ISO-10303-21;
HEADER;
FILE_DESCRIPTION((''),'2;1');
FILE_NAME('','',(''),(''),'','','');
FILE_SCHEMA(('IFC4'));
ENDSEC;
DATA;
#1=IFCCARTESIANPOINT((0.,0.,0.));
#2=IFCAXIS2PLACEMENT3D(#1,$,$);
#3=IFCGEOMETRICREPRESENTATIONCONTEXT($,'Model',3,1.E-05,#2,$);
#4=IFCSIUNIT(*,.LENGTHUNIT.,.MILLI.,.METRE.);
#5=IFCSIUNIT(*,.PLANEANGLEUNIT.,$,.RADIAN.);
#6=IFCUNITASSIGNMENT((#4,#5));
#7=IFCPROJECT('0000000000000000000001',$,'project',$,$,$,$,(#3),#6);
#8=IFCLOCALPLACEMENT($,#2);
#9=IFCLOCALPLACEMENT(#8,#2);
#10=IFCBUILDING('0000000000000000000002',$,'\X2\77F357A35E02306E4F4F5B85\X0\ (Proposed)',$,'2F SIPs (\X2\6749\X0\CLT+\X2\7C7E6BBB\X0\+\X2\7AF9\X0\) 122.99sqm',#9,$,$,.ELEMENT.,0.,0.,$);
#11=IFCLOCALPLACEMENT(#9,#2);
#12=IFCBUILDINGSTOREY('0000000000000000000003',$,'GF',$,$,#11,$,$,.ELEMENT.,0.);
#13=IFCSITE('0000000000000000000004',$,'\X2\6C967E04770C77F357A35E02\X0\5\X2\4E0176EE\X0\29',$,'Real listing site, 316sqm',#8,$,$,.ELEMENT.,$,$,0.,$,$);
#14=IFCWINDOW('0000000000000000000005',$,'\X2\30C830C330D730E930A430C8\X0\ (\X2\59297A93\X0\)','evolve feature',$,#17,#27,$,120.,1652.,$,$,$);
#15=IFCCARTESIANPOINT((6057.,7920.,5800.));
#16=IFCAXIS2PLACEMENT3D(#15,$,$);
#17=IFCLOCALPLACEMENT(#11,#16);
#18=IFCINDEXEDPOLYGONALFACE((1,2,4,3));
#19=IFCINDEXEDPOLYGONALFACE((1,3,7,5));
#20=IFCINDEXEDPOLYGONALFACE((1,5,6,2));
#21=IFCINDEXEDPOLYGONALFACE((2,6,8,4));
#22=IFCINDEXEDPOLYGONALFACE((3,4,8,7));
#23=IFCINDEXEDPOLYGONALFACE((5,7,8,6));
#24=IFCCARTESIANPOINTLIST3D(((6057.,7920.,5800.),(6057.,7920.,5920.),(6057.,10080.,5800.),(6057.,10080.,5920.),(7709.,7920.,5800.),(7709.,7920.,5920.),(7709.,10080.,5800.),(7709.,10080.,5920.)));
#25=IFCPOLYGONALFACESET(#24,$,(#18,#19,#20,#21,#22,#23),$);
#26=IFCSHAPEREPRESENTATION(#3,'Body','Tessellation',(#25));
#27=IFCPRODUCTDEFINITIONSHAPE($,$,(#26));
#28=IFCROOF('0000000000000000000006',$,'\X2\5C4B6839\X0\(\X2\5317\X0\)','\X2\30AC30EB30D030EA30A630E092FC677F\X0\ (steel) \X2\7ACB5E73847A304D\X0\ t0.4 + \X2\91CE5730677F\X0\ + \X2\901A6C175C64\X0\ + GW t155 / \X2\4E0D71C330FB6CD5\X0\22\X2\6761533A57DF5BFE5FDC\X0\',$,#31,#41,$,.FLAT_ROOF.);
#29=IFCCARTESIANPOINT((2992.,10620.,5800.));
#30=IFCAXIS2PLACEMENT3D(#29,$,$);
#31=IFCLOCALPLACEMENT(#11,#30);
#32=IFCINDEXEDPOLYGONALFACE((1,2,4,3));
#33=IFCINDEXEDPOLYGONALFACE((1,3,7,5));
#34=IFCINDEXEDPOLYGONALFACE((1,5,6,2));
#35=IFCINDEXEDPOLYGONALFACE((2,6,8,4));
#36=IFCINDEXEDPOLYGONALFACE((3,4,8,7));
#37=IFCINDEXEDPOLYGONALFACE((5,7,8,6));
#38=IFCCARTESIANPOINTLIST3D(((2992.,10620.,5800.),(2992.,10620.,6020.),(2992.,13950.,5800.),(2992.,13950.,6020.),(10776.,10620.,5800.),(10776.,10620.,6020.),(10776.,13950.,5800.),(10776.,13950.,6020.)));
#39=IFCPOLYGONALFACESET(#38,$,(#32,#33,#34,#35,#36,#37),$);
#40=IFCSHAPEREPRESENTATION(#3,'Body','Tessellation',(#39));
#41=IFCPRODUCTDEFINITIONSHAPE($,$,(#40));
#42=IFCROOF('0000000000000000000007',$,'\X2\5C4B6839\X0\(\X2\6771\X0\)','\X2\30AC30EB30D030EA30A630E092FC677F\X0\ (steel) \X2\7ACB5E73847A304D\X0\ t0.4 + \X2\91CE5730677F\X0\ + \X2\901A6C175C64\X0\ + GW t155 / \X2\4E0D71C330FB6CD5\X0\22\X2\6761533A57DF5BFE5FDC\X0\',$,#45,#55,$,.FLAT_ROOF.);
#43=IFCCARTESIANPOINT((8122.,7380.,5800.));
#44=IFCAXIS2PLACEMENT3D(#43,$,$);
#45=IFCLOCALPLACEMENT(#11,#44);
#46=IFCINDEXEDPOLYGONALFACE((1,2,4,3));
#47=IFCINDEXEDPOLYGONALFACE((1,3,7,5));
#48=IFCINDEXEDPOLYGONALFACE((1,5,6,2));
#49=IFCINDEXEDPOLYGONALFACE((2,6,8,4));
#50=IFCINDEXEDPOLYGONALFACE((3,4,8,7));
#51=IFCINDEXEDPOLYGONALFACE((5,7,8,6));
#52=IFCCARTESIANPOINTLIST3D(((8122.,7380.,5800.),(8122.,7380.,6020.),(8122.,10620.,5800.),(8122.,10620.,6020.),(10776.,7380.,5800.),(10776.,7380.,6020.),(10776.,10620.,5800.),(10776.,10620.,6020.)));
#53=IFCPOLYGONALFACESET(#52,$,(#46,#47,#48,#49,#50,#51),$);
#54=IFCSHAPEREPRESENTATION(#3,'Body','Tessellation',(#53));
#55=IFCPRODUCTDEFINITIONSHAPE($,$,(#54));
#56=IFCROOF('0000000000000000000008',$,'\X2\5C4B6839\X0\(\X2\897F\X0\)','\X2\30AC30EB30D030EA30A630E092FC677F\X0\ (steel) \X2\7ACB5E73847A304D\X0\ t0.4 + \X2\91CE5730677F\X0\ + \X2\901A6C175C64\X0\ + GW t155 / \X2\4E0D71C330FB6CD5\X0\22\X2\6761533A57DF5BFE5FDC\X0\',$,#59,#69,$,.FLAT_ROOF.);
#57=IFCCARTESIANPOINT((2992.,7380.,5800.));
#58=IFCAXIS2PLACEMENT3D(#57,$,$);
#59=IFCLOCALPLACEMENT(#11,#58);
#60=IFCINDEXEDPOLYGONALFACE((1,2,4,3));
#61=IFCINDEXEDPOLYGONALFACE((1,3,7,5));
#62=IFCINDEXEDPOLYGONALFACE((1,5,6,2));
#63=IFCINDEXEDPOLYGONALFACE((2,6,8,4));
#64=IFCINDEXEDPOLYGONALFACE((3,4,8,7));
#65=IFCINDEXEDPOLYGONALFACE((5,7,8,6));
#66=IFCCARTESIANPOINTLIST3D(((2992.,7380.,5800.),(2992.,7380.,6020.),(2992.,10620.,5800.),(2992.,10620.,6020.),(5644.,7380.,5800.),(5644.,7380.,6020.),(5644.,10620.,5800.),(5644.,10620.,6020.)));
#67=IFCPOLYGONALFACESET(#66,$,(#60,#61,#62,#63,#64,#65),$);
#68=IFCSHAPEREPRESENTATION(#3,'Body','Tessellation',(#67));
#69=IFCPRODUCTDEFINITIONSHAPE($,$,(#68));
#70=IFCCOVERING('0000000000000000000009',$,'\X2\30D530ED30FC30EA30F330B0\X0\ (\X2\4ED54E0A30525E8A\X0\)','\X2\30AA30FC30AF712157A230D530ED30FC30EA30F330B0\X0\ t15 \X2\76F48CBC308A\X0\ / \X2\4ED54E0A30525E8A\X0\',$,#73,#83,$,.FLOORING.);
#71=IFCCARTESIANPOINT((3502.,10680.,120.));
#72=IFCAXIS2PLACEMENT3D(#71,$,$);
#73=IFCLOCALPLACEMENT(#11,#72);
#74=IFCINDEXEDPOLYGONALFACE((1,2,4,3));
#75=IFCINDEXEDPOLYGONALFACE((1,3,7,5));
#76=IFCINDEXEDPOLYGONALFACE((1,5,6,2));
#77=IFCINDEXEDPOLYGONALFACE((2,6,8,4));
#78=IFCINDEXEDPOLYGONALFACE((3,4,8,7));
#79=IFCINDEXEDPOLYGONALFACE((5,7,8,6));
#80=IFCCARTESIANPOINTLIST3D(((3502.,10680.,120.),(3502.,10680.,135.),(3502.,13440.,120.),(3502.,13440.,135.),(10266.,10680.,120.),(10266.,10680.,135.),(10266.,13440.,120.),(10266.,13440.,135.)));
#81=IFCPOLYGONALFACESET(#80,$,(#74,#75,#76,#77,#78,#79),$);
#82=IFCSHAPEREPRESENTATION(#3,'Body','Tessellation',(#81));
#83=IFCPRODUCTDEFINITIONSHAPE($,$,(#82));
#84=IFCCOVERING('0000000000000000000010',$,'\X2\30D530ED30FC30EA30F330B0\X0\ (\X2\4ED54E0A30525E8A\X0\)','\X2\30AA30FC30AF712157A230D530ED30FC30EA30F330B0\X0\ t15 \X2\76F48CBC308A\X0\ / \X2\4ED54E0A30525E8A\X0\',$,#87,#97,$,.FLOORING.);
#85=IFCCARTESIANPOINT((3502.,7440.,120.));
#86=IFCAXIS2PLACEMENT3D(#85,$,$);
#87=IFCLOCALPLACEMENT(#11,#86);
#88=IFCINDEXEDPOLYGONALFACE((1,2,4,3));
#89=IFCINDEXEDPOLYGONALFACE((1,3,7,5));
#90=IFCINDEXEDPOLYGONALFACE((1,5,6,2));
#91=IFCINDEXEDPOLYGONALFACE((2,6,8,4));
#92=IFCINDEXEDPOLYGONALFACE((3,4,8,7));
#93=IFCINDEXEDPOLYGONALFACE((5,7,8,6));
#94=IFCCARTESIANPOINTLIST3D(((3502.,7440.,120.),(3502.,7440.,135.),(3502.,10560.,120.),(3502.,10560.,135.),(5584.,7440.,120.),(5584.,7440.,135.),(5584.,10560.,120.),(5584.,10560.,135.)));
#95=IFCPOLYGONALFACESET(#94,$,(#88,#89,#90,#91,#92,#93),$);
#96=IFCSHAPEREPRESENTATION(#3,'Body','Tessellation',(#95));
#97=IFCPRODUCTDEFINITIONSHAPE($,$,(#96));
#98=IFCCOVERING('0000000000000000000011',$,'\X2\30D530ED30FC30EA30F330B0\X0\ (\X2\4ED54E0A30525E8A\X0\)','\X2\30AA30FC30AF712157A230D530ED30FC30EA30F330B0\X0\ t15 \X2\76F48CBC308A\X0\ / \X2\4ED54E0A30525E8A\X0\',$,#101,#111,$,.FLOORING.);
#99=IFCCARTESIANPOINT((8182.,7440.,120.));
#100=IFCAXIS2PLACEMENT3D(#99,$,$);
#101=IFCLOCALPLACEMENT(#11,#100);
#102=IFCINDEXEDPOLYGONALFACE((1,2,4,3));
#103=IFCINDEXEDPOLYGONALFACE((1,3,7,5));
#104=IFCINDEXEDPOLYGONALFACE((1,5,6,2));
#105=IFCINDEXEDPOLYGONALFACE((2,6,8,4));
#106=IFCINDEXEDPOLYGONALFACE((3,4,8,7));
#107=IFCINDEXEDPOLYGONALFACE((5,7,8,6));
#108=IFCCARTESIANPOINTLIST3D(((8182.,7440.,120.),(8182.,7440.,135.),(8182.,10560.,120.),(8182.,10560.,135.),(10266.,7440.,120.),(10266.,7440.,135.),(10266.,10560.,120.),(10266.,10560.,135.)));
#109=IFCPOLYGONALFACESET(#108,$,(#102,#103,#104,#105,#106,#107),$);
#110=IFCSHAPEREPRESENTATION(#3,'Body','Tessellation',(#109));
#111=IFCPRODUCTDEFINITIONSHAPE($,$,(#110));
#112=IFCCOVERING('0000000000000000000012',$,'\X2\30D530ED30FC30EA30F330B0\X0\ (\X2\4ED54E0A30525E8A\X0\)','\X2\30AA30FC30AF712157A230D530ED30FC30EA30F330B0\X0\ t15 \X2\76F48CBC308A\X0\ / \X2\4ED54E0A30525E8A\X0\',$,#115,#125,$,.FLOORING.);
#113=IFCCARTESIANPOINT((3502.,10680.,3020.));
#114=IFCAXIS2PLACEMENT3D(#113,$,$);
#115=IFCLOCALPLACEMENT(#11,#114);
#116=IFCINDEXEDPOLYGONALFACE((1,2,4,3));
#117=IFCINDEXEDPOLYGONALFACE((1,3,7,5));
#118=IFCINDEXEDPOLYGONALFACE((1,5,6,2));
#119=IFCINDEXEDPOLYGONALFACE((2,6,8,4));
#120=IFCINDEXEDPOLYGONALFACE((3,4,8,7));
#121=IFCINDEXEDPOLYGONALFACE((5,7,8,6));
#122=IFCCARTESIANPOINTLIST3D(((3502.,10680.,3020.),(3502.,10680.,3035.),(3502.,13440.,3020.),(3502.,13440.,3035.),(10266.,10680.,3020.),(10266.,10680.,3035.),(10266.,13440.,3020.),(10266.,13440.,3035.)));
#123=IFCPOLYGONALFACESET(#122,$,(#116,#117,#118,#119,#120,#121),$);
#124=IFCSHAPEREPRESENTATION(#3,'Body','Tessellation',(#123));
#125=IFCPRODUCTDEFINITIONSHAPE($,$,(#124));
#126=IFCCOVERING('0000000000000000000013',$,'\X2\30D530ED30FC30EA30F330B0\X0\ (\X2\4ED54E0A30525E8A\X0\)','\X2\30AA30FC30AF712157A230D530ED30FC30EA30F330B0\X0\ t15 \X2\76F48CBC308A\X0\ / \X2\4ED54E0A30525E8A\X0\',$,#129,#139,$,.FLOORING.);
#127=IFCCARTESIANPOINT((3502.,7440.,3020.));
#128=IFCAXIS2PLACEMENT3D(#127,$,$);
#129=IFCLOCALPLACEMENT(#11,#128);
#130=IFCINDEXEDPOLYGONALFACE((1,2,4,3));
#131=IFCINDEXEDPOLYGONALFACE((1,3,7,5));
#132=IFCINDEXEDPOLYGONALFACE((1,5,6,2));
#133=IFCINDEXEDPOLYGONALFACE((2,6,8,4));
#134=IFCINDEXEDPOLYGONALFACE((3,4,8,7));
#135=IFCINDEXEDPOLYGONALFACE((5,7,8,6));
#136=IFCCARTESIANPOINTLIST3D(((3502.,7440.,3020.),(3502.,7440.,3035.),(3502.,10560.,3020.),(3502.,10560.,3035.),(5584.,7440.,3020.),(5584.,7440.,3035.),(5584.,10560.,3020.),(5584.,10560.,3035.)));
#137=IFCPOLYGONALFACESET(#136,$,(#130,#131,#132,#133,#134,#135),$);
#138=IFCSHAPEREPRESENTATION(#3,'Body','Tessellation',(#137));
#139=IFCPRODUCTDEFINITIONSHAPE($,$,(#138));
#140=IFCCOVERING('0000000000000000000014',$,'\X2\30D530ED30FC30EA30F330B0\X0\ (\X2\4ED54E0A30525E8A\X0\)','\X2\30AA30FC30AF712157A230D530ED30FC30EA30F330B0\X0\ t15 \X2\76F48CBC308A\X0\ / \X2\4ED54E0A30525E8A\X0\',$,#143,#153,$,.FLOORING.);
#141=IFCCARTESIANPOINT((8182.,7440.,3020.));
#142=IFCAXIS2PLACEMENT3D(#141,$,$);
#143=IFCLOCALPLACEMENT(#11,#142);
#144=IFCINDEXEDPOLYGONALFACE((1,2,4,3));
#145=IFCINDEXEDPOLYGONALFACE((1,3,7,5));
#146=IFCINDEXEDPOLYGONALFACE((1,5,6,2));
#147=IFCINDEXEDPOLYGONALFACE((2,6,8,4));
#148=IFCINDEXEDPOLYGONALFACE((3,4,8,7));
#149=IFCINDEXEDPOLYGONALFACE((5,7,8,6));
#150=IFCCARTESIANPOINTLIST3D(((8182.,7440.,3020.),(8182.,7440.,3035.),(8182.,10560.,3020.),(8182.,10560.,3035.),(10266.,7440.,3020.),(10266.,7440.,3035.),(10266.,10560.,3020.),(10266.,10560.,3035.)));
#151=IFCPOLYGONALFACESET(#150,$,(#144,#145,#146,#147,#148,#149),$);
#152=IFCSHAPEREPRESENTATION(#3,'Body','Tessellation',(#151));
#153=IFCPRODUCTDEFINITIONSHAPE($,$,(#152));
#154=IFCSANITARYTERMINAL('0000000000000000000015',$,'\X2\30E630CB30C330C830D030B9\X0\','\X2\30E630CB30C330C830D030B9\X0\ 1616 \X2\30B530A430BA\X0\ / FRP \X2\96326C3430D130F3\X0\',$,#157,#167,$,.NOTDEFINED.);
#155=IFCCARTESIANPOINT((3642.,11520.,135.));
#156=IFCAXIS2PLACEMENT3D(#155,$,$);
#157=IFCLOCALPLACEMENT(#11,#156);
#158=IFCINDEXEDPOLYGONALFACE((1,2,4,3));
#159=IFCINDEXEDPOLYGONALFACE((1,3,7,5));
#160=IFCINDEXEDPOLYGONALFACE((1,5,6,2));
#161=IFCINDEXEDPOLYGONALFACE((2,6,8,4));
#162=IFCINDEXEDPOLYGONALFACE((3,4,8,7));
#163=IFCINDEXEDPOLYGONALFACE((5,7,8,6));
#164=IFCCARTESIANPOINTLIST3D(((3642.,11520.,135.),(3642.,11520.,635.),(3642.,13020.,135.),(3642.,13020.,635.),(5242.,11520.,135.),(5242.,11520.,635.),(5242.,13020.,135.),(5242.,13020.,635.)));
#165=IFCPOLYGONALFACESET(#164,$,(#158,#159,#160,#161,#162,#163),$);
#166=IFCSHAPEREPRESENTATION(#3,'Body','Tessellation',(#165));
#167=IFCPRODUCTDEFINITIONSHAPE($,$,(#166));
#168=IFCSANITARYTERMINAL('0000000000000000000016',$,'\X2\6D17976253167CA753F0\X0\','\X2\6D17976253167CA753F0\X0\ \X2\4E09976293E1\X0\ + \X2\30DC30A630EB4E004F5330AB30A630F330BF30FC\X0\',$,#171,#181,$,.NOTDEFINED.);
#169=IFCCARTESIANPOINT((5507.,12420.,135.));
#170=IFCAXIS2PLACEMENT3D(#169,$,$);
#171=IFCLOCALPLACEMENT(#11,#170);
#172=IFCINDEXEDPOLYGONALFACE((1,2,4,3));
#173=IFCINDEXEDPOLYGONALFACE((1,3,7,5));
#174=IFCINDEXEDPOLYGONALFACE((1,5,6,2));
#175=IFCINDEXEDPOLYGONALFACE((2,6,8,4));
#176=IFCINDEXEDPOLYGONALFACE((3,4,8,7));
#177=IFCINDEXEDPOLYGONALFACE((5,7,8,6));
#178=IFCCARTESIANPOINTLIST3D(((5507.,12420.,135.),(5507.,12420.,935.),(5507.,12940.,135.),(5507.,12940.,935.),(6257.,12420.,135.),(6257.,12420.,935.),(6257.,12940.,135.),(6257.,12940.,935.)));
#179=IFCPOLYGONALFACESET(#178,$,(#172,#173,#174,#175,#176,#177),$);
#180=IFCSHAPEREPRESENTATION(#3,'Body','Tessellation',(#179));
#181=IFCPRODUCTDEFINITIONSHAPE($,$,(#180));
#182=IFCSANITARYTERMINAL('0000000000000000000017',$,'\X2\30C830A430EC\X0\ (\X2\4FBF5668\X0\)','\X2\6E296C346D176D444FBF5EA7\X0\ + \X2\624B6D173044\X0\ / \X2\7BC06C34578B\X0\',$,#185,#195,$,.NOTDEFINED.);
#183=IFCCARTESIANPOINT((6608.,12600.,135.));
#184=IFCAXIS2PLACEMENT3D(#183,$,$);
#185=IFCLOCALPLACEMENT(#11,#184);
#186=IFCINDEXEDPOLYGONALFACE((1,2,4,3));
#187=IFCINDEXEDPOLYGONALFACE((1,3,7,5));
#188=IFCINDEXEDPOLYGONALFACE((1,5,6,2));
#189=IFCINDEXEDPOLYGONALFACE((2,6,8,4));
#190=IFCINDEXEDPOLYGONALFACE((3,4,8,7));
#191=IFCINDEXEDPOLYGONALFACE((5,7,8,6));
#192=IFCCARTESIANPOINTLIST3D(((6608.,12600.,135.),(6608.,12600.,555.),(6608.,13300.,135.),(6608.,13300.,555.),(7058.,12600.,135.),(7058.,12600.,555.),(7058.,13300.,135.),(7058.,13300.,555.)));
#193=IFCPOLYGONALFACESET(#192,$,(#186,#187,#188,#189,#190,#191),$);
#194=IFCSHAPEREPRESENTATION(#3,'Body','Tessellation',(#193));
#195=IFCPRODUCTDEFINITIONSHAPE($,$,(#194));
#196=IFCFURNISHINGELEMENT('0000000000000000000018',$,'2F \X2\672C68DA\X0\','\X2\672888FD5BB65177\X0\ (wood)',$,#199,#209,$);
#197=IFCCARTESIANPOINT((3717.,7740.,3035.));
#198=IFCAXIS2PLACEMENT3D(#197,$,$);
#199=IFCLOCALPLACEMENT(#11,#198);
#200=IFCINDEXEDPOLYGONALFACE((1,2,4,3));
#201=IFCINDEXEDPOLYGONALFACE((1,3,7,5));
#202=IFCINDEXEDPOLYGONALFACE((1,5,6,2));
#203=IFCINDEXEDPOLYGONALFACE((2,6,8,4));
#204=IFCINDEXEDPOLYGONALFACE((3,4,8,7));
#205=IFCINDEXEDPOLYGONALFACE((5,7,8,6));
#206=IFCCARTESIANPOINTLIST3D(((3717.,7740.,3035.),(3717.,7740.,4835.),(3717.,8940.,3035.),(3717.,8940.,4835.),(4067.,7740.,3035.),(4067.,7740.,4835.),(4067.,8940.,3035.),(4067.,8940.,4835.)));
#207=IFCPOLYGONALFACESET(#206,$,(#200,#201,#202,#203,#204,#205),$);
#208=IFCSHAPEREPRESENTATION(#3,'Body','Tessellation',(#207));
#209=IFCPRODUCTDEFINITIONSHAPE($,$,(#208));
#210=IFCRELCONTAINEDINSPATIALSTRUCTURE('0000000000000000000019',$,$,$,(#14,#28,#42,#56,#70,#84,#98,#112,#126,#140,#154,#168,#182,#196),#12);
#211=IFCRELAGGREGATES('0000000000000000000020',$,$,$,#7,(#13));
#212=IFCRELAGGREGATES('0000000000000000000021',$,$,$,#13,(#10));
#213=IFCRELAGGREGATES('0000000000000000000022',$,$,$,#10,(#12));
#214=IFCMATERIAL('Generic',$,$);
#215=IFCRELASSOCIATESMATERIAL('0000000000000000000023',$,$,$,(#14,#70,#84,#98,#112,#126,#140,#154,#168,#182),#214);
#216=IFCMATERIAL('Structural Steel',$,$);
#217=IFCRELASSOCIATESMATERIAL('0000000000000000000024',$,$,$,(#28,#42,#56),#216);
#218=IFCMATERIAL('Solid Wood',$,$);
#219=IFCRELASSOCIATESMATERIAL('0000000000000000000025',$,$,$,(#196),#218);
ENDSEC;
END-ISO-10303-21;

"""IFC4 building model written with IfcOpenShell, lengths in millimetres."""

from ifc_helpers import new_model, si_unit, frame, frame_2d, origin, place, context, project, spatial, rectangle, extrude, material, element, save


model = new_model("IFC4")

# Units and contexts
model_context = context("Model", 3, precision=1e-05, world=origin())
ifc_project = project(units=[si_unit("LENGTHUNIT", "METRE", prefix="MILLI"), si_unit("PLANEANGLEUNIT", "RADIAN")], contexts=[model_context])

# Site, building, storey
site_placement = place(None, origin())
site = spatial("IfcSite", under=ifc_project, at=site_placement, Name="沖縄県石垣市5丁目29", ObjectType="Real listing site, 316sqm", CompositionType="ELEMENT", RefElevation=0.0)
building_placement = place(site_placement, origin())
building = spatial("IfcBuilding", under=site, at=building_placement, Name="石垣市の住宅 (Proposed)", ObjectType="2F SIPs (杉CLT+籾殻+竹) 122.99sqm", CompositionType="ELEMENT", ElevationOfRefHeight=0.0, ElevationOfTerrain=0.0)
storey_placement = place(building_placement, origin())
storey = spatial("IfcBuildingStorey", under=building, at=storey_placement, Name="GF", CompositionType="ELEMENT", Elevation=0.0)

# Shared definitions
ifc_material_1 = material(Name="Solid Wood")

# Window
ifc_material_2 = material(Name="Generic")
window_1_placement = place(storey_placement, frame((6057.0, 7920.0, 5800.0)))
element("IfcWindow", 1, at=window_1_placement, inside=storey, material=ifc_material_2, Name="トップライト (天窓)", Description="evolve feature", OverallHeight=120.0, OverallWidth=1652.0, context=model_context, shape_type="SweptSolid", body=[
    extrude(rectangle(XDim=1652.0, YDim=2160.0, at=frame_2d((826.0, 1080.0))), frame((6057.0, 7920.0, 5800.0)), (0.0, 0.0, 1.0), 120.0),
])

# Roofs
ifc_material_3 = material(Name="Structural Steel")
roof_1_placement = place(storey_placement, frame((2992.0, 10620.0, 5800.0)))
element("IfcRoof", 2, at=roof_1_placement, inside=storey, material=ifc_material_3, Name="屋根(北)", Description="ガルバリウム鋼板 (steel) 立平葺き t0.4 + 野地板 + 通気層 + GW t155 / 不燃・法22条区域対応", PredefinedType="FLAT_ROOF", context=model_context, shape_type="SweptSolid", body=[
    extrude(rectangle(XDim=7784.0, YDim=3330.0, at=frame_2d((3892.0, 1665.0))), frame((2992.0, 10620.0, 5800.0)), (0.0, 0.0, 1.0), 220.0),
])
roof_2_placement = place(storey_placement, frame((8122.0, 7380.0, 5800.0)))
element("IfcRoof", 3, at=roof_2_placement, inside=storey, material=ifc_material_3, Name="屋根(東)", Description="ガルバリウム鋼板 (steel) 立平葺き t0.4 + 野地板 + 通気層 + GW t155 / 不燃・法22条区域対応", PredefinedType="FLAT_ROOF", context=model_context, shape_type="SweptSolid", body=[
    extrude(rectangle(XDim=2654.0, YDim=3240.0, at=frame_2d((1327.0, 1620.0))), frame((8122.0, 7380.0, 5800.0)), (0.0, 0.0, 1.0), 220.0),
])
roof_3_placement = place(storey_placement, frame((2992.0, 7380.0, 5800.0)))
element("IfcRoof", 4, at=roof_3_placement, inside=storey, material=ifc_material_3, Name="屋根(西)", Description="ガルバリウム鋼板 (steel) 立平葺き t0.4 + 野地板 + 通気層 + GW t155 / 不燃・法22条区域対応", PredefinedType="FLAT_ROOF", context=model_context, shape_type="SweptSolid", body=[
    extrude(rectangle(XDim=2652.0, YDim=3240.0, at=frame_2d((1326.0, 1620.0))), frame((2992.0, 7380.0, 5800.0)), (0.0, 0.0, 1.0), 220.0),
])

# Coverings
covering_1_placement = place(storey_placement, frame((3502.0, 10680.0, 120.0)))
element("IfcCovering", 5, at=covering_1_placement, inside=storey, material=ifc_material_2, Name="フローリング (仕上げ床)", Description="オーク無垢フローリング t15 直貼り / 仕上げ床", PredefinedType="FLOORING", context=model_context, shape_type="SweptSolid", body=[
    extrude(rectangle(XDim=6764.0, YDim=2760.0, at=frame_2d((3382.0, 1380.0))), frame((3502.0, 10680.0, 120.0)), (0.0, 0.0, 1.0), 15.0),
])
covering_2_placement = place(storey_placement, frame((3502.0, 7440.0, 120.0)))
element("IfcCovering", 6, at=covering_2_placement, inside=storey, material=ifc_material_2, Name="フローリング (仕上げ床)", Description="オーク無垢フローリング t15 直貼り / 仕上げ床", PredefinedType="FLOORING", context=model_context, shape_type="SweptSolid", body=[
    extrude(rectangle(XDim=2082.0, YDim=3120.0, at=frame_2d((1041.0, 1560.0))), frame((3502.0, 7440.0, 120.0)), (0.0, 0.0, 1.0), 15.0),
])
covering_3_placement = place(storey_placement, frame((8182.0, 7440.0, 120.0)))
element("IfcCovering", 7, at=covering_3_placement, inside=storey, material=ifc_material_2, Name="フローリング (仕上げ床)", Description="オーク無垢フローリング t15 直貼り / 仕上げ床", PredefinedType="FLOORING", context=model_context, shape_type="SweptSolid", body=[
    extrude(rectangle(XDim=2084.0, YDim=3120.0, at=frame_2d((1042.0, 1560.0))), frame((8182.0, 7440.0, 120.0)), (0.0, 0.0, 1.0), 15.0),
])
covering_4_placement = place(storey_placement, frame((3502.0, 10680.0, 3020.0)))
element("IfcCovering", 8, at=covering_4_placement, inside=storey, material=ifc_material_2, Name="フローリング (仕上げ床)", Description="オーク無垢フローリング t15 直貼り / 仕上げ床", PredefinedType="FLOORING", context=model_context, shape_type="SweptSolid", body=[
    extrude(rectangle(XDim=6764.0, YDim=2760.0, at=frame_2d((3382.0, 1380.0))), frame((3502.0, 10680.0, 3020.0)), (0.0, 0.0, 1.0), 15.0),
])
covering_5_placement = place(storey_placement, frame((3502.0, 7440.0, 3020.0)))
element("IfcCovering", 9, at=covering_5_placement, inside=storey, material=ifc_material_2, Name="フローリング (仕上げ床)", Description="オーク無垢フローリング t15 直貼り / 仕上げ床", PredefinedType="FLOORING", context=model_context, shape_type="SweptSolid", body=[
    extrude(rectangle(XDim=2082.0, YDim=3120.0, at=frame_2d((1041.0, 1560.0))), frame((3502.0, 7440.0, 3020.0)), (0.0, 0.0, 1.0), 15.0),
])
covering_6_placement = place(storey_placement, frame((8182.0, 7440.0, 3020.0)))
element("IfcCovering", 10, at=covering_6_placement, inside=storey, material=ifc_material_2, Name="フローリング (仕上げ床)", Description="オーク無垢フローリング t15 直貼り / 仕上げ床", PredefinedType="FLOORING", context=model_context, shape_type="SweptSolid", body=[
    extrude(rectangle(XDim=2084.0, YDim=3120.0, at=frame_2d((1042.0, 1560.0))), frame((8182.0, 7440.0, 3020.0)), (0.0, 0.0, 1.0), 15.0),
])

# Sanitary terminals
sanitary_terminal_1_placement = place(storey_placement, frame((3642.0, 11520.0, 135.0)))
element("IfcSanitaryTerminal", 11, at=sanitary_terminal_1_placement, inside=storey, material=ifc_material_2, Name="ユニットバス", Description="ユニットバス 1616 サイズ / FRP 防水パン", PredefinedType="NOTDEFINED", context=model_context, shape_type="SweptSolid", body=[
    extrude(rectangle(XDim=1600.0, YDim=1500.0, at=frame_2d((800.0, 750.0))), frame((3642.0, 11520.0, 135.0)), (0.0, 0.0, 1.0), 500.0),
])
sanitary_terminal_2_placement = place(storey_placement, frame((5507.0, 12420.0, 135.0)))
element("IfcSanitaryTerminal", 12, at=sanitary_terminal_2_placement, inside=storey, material=ifc_material_2, Name="洗面化粧台", Description="洗面化粧台 三面鏡 + ボウル一体カウンター", PredefinedType="NOTDEFINED", context=model_context, shape_type="SweptSolid", body=[
    extrude(rectangle(XDim=750.0, YDim=520.0, at=frame_2d((375.0, 260.0))), frame((5507.0, 12420.0, 135.0)), (0.0, 0.0, 1.0), 800.0),
])
sanitary_terminal_3_placement = place(storey_placement, frame((6608.0, 12600.0, 135.0)))
element("IfcSanitaryTerminal", 13, at=sanitary_terminal_3_placement, inside=storey, material=ifc_material_2, Name="トイレ (便器)", Description="温水洗浄便座 + 手洗い / 節水型", PredefinedType="NOTDEFINED", context=model_context, shape_type="SweptSolid", body=[
    extrude(rectangle(XDim=450.0, YDim=700.0, at=frame_2d((225.0, 350.0))), frame((6608.0, 12600.0, 135.0)), (0.0, 0.0, 1.0), 420.0),
])

# Furnishing element
furnishing_placement = place(storey_placement, frame((3717.0, 7740.0, 3035.0)))
element("IfcFurnishingElement", 14, at=furnishing_placement, inside=storey, material=ifc_material_1, Name="2F 本棚", Description="木製家具 (wood)", context=model_context, shape_type="SweptSolid", body=[
    extrude(rectangle(XDim=350.0, YDim=1200.0, at=frame_2d((175.0, 600.0))), frame((3717.0, 7740.0, 3035.0)), (0.0, 0.0, 1.0), 1800.0),
])

save(model, "model.ifc")
